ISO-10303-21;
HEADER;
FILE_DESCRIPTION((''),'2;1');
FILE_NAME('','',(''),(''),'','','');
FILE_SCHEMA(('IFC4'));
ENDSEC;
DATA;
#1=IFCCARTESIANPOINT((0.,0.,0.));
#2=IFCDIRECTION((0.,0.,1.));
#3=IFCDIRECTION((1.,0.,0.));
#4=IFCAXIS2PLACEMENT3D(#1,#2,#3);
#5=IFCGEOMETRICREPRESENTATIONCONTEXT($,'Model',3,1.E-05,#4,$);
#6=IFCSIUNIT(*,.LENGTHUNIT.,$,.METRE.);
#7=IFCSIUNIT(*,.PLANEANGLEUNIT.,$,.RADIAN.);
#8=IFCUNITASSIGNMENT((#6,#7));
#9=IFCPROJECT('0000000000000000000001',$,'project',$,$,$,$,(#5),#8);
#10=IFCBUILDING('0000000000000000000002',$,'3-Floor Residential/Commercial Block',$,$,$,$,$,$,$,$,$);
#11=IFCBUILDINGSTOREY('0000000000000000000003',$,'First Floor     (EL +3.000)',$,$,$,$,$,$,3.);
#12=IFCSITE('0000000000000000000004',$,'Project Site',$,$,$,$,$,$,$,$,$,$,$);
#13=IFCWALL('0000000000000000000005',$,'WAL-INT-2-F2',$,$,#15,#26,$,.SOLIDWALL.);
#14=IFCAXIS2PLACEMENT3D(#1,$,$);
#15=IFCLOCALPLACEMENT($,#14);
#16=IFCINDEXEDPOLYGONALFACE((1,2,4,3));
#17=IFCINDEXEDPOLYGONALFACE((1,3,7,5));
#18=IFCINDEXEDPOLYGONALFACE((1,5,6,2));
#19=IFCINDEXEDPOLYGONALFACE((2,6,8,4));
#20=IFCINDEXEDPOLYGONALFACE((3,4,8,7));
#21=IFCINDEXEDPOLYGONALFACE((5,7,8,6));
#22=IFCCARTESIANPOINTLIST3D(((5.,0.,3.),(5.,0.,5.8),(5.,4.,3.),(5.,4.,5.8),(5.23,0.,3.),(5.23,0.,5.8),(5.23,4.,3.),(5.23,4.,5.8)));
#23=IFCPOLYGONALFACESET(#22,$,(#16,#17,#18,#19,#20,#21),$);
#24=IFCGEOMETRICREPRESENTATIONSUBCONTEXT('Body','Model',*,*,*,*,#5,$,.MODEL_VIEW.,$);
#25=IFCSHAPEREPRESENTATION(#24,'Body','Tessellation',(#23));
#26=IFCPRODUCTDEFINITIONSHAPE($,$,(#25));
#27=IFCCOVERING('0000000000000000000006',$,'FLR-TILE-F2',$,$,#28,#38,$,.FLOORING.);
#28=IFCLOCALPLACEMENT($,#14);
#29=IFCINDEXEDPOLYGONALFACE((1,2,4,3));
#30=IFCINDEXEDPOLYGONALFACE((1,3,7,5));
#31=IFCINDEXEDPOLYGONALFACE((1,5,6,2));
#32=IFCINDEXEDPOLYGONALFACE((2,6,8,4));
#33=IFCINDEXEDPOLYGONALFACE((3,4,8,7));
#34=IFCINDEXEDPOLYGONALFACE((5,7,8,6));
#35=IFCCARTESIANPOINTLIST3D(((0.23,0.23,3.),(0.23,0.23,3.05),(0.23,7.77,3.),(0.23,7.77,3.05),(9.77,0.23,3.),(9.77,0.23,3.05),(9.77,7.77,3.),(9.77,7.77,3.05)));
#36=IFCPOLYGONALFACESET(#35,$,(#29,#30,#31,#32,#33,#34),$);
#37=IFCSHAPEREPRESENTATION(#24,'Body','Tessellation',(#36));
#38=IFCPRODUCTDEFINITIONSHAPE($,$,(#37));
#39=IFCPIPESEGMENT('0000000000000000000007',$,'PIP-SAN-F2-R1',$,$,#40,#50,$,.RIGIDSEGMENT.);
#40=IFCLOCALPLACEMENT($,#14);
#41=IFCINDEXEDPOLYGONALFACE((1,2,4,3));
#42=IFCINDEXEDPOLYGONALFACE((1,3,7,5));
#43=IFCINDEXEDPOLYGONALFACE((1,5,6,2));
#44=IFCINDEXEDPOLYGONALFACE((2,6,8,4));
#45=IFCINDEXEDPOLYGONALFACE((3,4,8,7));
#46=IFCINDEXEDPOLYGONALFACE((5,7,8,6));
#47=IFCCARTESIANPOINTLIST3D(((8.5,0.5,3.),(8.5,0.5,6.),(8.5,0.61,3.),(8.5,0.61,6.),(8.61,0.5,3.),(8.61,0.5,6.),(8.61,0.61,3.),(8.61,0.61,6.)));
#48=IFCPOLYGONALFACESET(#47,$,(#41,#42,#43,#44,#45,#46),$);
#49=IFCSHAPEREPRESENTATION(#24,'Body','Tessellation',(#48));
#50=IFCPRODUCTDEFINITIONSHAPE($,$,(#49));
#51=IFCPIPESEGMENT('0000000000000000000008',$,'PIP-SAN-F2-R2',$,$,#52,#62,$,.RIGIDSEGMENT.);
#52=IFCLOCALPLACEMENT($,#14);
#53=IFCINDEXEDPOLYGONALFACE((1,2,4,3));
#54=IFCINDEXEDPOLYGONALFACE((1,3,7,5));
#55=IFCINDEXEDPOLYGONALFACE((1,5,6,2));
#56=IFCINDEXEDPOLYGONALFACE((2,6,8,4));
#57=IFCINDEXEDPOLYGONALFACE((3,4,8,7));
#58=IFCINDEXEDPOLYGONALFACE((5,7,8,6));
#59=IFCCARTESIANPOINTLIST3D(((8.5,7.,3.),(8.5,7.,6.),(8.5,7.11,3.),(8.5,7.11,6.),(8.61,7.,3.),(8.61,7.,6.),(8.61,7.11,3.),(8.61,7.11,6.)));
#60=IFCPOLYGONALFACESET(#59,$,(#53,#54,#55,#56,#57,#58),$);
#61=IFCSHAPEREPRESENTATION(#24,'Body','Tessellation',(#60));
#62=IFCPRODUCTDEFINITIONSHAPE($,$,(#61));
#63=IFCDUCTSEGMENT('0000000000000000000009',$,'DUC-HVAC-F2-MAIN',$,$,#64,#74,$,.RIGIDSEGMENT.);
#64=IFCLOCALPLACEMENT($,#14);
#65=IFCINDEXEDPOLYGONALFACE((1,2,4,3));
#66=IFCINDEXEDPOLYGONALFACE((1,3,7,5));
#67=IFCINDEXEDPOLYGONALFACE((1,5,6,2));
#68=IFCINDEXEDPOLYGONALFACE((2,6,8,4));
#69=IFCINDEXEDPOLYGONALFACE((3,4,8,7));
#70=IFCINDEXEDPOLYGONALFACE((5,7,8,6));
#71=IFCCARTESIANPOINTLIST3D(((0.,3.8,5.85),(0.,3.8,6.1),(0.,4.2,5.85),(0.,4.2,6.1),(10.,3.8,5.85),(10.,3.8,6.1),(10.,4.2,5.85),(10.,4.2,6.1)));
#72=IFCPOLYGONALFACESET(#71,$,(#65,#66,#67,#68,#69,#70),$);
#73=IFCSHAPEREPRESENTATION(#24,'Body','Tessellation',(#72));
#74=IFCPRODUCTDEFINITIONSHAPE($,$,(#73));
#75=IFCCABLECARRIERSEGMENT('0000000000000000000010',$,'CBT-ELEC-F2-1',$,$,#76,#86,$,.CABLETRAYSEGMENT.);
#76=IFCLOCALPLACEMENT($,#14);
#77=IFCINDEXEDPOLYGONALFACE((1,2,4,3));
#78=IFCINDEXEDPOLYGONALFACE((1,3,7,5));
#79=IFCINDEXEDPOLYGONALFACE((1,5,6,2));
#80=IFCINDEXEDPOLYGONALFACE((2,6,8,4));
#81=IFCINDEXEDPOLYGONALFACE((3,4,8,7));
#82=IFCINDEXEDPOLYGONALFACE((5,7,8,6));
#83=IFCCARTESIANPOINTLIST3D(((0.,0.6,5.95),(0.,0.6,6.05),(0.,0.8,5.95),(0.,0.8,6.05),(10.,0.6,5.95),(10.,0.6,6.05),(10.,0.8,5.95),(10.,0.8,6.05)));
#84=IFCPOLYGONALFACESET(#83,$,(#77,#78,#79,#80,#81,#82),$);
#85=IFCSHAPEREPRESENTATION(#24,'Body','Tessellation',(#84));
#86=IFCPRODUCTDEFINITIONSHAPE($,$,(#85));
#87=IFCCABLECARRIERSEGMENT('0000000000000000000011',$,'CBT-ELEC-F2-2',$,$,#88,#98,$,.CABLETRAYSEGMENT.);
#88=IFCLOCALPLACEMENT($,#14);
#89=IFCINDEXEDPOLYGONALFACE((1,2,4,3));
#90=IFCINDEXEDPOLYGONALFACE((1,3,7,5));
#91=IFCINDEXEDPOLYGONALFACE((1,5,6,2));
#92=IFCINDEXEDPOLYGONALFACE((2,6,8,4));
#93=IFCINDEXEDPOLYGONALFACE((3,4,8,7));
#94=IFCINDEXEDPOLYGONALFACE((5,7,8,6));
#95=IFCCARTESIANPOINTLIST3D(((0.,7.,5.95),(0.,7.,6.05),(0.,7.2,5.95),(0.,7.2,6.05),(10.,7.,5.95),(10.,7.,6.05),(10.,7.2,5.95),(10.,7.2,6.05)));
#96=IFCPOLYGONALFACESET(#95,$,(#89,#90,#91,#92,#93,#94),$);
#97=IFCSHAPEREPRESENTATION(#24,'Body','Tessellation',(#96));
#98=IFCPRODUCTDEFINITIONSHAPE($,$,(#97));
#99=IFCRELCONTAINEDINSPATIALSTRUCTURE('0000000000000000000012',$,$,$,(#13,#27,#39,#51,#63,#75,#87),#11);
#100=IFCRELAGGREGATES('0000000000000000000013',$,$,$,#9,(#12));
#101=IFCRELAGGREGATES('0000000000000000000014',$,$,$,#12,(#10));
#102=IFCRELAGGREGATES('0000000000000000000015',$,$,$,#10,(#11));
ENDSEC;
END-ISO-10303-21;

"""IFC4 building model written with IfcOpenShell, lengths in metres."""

from ifc_helpers import new_model, si_unit, frame, frame_2d, origin_with_axes, place, context, subcontext, project, spatial, rectangle, extrude, element, save


model = new_model("IFC4")

# Units and contexts
model_context = context("Model", 3, precision=1e-05, world=origin_with_axes())
body_context = subcontext(model_context, "Body", "Model", "MODEL_VIEW")
ifc_project = project(units=[si_unit("LENGTHUNIT", "METRE"), si_unit("PLANEANGLEUNIT", "RADIAN")], contexts=[model_context])

# Site, building, storey
site = spatial("IfcSite", under=ifc_project, Name="Project Site")
building = spatial("IfcBuilding", under=site, Name="3-Floor Residential/Commercial Block")
storey = spatial("IfcBuildingStorey", under=building, Name="First Floor     (EL +3.000)", Elevation=3.0)

# Wall
wall_1_placement = place(None, frame((5.0, 0.0, 3.0), z_axis=(0.0, 0.0, 1.0), x_axis=(1.0, 0.0, 0.0)))
element("IfcWall", 1, at=wall_1_placement, inside=storey, Name="WAL-INT-2-F2", PredefinedType="SOLIDWALL", context=body_context, shape_type="SweptSolid", body=[
    extrude(rectangle(XDim=0.23, YDim=4.0, at=frame_2d((0.115, 2.0))), origin_with_axes(), (0.0, 0.0, 1.0), 2.8),
])

# Covering
covering_placement = place(None, frame((0.23, 0.23, 3.0), z_axis=(0.0, 0.0, 1.0), x_axis=(1.0, 0.0, 0.0)))
element("IfcCovering", 2, at=covering_placement, inside=storey, Name="FLR-TILE-F2", PredefinedType="FLOORING", context=body_context, shape_type="SweptSolid", body=[
    extrude(rectangle(XDim=9.54, YDim=7.54, at=frame_2d((4.77, 3.77))), origin_with_axes(), (0.0, 0.0, 1.0), 0.05),
])

# Pipe segments
for number, where, z_axis, x_axis, name in (
    (3, (8.5, 0.5, 3.0), (0.0, 0.0, 1.0), (1.0, 0.0, 0.0), "PIP-SAN-F2-R1"),
    (4, (8.5, 7.0, 3.0), (0.0, 0.0, 1.0), (1.0, 0.0, 0.0), "PIP-SAN-F2-R2"),
):
    element("IfcPipeSegment", number, at=place(None, frame(where, z_axis=z_axis, x_axis=x_axis)), inside=storey, Name=name, PredefinedType="RIGIDSEGMENT", context=body_context, shape_type="SweptSolid", body=[
        extrude(rectangle(XDim=0.11, YDim=0.11, at=frame_2d((0.055, 0.055))), origin_with_axes(), (0.0, 0.0, 1.0), 3.0),
    ])

# Duct segment
duct_segment_placement = place(None, frame((0.0, 3.8, 5.85), z_axis=(0.0, 0.0, 1.0), x_axis=(1.0, 0.0, 0.0)))
element("IfcDuctSegment", 5, at=duct_segment_placement, inside=storey, Name="DUC-HVAC-F2-MAIN", PredefinedType="RIGIDSEGMENT", context=body_context, shape_type="SweptSolid", body=[
    extrude(rectangle(XDim=10.0, YDim=0.4, at=frame_2d((5.0, 0.2))), origin_with_axes(), (0.0, 0.0, 1.0), 0.25),
])

# Cable carrier segments
for number, where, z_axis, x_axis, name in (
    (6, (0.0, 0.6, 5.95), (0.0, 0.0, 1.0), (1.0, 0.0, 0.0), "CBT-ELEC-F2-1"),
    (7, (0.0, 7.0, 5.95), (0.0, 0.0, 1.0), (1.0, 0.0, 0.0), "CBT-ELEC-F2-2"),
):
    element("IfcCableCarrierSegment", number, at=place(None, frame(where, z_axis=z_axis, x_axis=x_axis)), inside=storey, Name=name, PredefinedType="CABLETRAYSEGMENT", context=body_context, shape_type="SweptSolid", body=[
        extrude(rectangle(XDim=10.0, YDim=0.2, at=frame_2d((5.0, 0.1))), origin_with_axes(), (0.0, 0.0, 1.0), 0.1),
    ])

save(model, "model.ifc")
